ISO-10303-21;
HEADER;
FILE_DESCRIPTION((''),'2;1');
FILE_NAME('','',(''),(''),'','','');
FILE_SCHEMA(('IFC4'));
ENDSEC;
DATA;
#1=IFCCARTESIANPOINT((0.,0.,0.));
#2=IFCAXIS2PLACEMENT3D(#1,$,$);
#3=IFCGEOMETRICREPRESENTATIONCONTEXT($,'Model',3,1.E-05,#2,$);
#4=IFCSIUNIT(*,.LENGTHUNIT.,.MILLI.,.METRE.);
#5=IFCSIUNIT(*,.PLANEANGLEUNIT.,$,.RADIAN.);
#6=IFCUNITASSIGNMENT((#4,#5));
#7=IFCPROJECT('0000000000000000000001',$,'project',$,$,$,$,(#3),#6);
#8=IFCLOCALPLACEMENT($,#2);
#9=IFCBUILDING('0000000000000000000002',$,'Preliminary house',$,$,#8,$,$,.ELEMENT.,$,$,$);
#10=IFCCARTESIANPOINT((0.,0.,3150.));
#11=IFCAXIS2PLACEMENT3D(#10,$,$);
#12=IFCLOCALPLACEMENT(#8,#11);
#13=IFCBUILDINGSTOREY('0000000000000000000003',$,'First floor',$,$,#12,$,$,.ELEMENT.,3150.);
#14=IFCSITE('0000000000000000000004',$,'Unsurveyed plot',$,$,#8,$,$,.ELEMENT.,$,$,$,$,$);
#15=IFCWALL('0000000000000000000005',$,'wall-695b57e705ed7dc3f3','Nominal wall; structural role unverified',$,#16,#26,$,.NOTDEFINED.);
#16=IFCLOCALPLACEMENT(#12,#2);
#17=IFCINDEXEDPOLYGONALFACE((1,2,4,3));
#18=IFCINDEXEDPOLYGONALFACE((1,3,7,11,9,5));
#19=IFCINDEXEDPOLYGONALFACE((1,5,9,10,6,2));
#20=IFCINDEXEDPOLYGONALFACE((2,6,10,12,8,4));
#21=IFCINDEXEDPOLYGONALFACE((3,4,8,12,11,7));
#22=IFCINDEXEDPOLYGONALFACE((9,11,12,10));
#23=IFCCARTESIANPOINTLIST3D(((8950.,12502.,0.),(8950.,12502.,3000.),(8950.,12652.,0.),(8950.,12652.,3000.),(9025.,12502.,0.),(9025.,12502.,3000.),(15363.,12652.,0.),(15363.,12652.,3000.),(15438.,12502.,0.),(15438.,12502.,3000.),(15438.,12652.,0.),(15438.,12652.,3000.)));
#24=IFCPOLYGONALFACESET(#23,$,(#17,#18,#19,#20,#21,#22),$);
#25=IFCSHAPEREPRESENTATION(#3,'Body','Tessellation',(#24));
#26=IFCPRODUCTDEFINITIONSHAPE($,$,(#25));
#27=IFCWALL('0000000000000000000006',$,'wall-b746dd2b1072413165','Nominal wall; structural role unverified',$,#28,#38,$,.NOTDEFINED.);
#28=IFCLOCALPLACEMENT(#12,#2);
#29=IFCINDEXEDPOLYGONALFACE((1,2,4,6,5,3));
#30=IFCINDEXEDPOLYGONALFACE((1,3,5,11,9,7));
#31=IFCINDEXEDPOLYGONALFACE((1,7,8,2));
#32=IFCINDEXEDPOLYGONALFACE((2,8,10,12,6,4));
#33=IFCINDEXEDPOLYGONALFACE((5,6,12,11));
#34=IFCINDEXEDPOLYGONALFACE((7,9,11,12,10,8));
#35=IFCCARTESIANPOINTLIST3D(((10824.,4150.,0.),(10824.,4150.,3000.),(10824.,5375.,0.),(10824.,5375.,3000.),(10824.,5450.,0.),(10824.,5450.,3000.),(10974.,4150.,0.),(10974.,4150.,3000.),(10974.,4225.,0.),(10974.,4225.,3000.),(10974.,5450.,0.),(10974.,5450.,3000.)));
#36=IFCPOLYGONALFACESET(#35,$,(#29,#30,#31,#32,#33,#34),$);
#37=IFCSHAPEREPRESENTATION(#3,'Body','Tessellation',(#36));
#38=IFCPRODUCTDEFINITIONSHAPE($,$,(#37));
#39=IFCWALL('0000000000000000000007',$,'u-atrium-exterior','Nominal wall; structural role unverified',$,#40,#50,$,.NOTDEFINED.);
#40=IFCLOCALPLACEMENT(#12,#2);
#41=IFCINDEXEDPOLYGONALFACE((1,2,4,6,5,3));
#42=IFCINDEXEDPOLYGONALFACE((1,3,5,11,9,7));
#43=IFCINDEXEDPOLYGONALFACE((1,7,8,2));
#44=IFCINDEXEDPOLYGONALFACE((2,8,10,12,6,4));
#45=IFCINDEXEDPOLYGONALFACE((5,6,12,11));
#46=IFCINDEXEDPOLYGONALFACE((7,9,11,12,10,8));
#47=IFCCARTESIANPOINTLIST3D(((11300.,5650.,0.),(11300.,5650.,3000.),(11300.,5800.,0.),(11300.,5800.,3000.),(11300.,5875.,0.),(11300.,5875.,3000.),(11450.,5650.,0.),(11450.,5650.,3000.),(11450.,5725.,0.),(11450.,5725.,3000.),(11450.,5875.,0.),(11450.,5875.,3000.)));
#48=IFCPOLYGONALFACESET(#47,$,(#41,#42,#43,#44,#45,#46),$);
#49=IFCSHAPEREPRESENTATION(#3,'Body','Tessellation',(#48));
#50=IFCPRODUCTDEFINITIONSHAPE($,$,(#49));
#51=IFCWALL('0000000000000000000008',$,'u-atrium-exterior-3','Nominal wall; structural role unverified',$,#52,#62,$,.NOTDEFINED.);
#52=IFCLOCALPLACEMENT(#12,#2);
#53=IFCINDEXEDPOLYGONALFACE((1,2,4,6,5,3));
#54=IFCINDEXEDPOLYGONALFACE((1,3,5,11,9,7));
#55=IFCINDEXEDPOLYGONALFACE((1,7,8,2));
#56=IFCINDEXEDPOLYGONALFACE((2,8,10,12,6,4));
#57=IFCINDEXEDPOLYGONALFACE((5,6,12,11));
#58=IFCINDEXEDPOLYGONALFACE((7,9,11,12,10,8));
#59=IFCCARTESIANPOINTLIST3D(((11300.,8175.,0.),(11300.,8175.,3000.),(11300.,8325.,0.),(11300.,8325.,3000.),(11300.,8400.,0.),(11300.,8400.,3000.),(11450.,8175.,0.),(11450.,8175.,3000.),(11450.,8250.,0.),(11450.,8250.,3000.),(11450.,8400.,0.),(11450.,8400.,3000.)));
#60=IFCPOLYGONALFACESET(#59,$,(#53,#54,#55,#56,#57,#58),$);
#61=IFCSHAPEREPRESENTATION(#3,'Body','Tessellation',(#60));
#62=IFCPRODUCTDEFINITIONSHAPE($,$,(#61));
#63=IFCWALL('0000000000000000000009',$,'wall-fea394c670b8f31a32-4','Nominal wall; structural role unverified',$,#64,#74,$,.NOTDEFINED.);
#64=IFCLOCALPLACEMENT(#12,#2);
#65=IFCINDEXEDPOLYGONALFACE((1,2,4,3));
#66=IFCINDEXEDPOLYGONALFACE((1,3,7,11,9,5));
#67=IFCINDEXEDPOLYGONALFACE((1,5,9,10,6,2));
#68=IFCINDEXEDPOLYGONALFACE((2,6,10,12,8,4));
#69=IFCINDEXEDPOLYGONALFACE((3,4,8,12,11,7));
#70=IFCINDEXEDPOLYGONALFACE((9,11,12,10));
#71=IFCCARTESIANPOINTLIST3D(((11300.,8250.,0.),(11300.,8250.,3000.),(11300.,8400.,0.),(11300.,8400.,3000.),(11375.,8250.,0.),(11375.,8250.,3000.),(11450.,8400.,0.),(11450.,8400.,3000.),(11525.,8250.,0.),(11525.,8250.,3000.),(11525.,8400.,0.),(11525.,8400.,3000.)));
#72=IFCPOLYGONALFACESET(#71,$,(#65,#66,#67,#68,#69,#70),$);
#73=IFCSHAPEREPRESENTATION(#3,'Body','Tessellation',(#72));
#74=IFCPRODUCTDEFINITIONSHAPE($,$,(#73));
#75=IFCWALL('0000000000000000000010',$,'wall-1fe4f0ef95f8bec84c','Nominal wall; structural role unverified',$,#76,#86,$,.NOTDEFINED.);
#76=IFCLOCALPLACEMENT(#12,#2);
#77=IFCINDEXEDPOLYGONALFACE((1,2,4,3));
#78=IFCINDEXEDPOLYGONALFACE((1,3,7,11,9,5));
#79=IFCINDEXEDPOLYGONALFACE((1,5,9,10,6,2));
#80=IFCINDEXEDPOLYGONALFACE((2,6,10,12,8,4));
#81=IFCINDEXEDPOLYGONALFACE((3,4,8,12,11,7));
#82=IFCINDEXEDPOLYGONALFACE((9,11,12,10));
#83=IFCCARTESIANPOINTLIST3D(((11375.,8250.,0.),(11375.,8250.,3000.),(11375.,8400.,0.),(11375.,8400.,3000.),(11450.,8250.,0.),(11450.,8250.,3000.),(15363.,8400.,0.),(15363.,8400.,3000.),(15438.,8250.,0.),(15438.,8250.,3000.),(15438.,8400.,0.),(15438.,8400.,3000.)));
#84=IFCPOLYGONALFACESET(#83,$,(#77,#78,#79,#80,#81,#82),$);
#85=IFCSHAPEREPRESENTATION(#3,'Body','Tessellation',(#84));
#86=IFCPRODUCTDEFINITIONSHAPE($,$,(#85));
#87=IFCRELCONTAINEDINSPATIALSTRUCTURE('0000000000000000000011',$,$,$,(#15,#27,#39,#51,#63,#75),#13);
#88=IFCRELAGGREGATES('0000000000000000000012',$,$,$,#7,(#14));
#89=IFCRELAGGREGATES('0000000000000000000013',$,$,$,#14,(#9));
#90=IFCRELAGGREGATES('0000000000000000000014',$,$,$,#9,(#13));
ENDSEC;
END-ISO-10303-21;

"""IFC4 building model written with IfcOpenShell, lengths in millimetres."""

from ifc_helpers import new_model, si_unit, frame, origin, place, context, project, spatial, polyline, outline, extrude, element, save


model = new_model("IFC4")

# Units and contexts
model_context = context("Model", 3, precision=1e-05, world=origin())
ifc_project = project(units=[si_unit("LENGTHUNIT", "METRE", prefix="MILLI"), si_unit("PLANEANGLEUNIT", "RADIAN")], contexts=[model_context])

# Site, building, storey
placement_1 = place(None, origin())
site = spatial("IfcSite", under=ifc_project, at=placement_1, Name="Unsurveyed plot", CompositionType="ELEMENT")
building = spatial("IfcBuilding", under=site, at=placement_1, Name="Preliminary house", CompositionType="ELEMENT")
placement_2 = place(placement_1, frame((0.0, 0.0, 3150.0)))
storey = spatial("IfcBuildingStorey", under=building, at=placement_2, Name="First floor", CompositionType="ELEMENT", Elevation=3150.0)

# Wall
element("IfcWall", 1, at=placement_2, inside=storey, Name="wall-695b57e705ed7dc3f3", Description="Nominal wall; structural role unverified", PredefinedType="NOTDEFINED", context=model_context, shape_type="SweptSolid", body=[
    extrude(outline(polyline([(15363.0, 12652.0), (15438.0, 12652.0), (15438.0, 12502.0), (9025.0, 12502.0), (8950.0, 12502.0), (8950.0, 12652.0), (15363.0, 12652.0)])), origin(), (0.0, 0.0, 1.0), 3000.0),
])

# Walls
element("IfcWall", 2, at=placement_2, inside=storey, Name="wall-b746dd2b1072413165", Description="Nominal wall; structural role unverified", PredefinedType="NOTDEFINED", context=model_context, shape_type="SweptSolid", body=[
    extrude(outline(polyline([(10824.0, 5375.0), (10824.0, 5450.0), (10974.0, 5450.0), (10974.0, 4225.0), (10974.0, 4150.0), (10824.0, 4150.0), (10824.0, 5375.0)])), origin(), (0.0, 0.0, 1.0), 3000.0),
])
element("IfcWall", 3, at=placement_2, inside=storey, Name="u-atrium-exterior", Description="Nominal wall; structural role unverified", PredefinedType="NOTDEFINED", context=model_context, shape_type="SweptSolid", body=[
    extrude(outline(polyline([(11300.0, 5800.0), (11300.0, 5875.0), (11450.0, 5875.0), (11450.0, 5725.0), (11450.0, 5650.0), (11300.0, 5650.0), (11300.0, 5800.0)])), origin(), (0.0, 0.0, 1.0), 3000.0),
])

# Walls
element("IfcWall", 4, at=placement_2, inside=storey, Name="u-atrium-exterior-3", Description="Nominal wall; structural role unverified", PredefinedType="NOTDEFINED", context=model_context, shape_type="SweptSolid", body=[
    extrude(outline(polyline([(11300.0, 8325.0), (11300.0, 8400.0), (11450.0, 8400.0), (11450.0, 8250.0), (11450.0, 8175.0), (11300.0, 8175.0), (11300.0, 8325.0)])), origin(), (0.0, 0.0, 1.0), 3000.0),
])
element("IfcWall", 5, at=placement_2, inside=storey, Name="wall-fea394c670b8f31a32-4", Description="Nominal wall; structural role unverified", PredefinedType="NOTDEFINED", context=model_context, shape_type="SweptSolid", body=[
    extrude(outline(polyline([(11450.0, 8400.0), (11525.0, 8400.0), (11525.0, 8250.0), (11375.0, 8250.0), (11300.0, 8250.0), (11300.0, 8400.0), (11450.0, 8400.0)])), origin(), (0.0, 0.0, 1.0), 3000.0),
])
element("IfcWall", 6, at=placement_2, inside=storey, Name="wall-1fe4f0ef95f8bec84c", Description="Nominal wall; structural role unverified", PredefinedType="NOTDEFINED", context=model_context, shape_type="SweptSolid", body=[
    extrude(outline(polyline([(15363.0, 8400.0), (15438.0, 8400.0), (15438.0, 8250.0), (11450.0, 8250.0), (11375.0, 8250.0), (11375.0, 8400.0), (15363.0, 8400.0)])), origin(), (0.0, 0.0, 1.0), 3000.0),
])

save(model, "model.ifc")
